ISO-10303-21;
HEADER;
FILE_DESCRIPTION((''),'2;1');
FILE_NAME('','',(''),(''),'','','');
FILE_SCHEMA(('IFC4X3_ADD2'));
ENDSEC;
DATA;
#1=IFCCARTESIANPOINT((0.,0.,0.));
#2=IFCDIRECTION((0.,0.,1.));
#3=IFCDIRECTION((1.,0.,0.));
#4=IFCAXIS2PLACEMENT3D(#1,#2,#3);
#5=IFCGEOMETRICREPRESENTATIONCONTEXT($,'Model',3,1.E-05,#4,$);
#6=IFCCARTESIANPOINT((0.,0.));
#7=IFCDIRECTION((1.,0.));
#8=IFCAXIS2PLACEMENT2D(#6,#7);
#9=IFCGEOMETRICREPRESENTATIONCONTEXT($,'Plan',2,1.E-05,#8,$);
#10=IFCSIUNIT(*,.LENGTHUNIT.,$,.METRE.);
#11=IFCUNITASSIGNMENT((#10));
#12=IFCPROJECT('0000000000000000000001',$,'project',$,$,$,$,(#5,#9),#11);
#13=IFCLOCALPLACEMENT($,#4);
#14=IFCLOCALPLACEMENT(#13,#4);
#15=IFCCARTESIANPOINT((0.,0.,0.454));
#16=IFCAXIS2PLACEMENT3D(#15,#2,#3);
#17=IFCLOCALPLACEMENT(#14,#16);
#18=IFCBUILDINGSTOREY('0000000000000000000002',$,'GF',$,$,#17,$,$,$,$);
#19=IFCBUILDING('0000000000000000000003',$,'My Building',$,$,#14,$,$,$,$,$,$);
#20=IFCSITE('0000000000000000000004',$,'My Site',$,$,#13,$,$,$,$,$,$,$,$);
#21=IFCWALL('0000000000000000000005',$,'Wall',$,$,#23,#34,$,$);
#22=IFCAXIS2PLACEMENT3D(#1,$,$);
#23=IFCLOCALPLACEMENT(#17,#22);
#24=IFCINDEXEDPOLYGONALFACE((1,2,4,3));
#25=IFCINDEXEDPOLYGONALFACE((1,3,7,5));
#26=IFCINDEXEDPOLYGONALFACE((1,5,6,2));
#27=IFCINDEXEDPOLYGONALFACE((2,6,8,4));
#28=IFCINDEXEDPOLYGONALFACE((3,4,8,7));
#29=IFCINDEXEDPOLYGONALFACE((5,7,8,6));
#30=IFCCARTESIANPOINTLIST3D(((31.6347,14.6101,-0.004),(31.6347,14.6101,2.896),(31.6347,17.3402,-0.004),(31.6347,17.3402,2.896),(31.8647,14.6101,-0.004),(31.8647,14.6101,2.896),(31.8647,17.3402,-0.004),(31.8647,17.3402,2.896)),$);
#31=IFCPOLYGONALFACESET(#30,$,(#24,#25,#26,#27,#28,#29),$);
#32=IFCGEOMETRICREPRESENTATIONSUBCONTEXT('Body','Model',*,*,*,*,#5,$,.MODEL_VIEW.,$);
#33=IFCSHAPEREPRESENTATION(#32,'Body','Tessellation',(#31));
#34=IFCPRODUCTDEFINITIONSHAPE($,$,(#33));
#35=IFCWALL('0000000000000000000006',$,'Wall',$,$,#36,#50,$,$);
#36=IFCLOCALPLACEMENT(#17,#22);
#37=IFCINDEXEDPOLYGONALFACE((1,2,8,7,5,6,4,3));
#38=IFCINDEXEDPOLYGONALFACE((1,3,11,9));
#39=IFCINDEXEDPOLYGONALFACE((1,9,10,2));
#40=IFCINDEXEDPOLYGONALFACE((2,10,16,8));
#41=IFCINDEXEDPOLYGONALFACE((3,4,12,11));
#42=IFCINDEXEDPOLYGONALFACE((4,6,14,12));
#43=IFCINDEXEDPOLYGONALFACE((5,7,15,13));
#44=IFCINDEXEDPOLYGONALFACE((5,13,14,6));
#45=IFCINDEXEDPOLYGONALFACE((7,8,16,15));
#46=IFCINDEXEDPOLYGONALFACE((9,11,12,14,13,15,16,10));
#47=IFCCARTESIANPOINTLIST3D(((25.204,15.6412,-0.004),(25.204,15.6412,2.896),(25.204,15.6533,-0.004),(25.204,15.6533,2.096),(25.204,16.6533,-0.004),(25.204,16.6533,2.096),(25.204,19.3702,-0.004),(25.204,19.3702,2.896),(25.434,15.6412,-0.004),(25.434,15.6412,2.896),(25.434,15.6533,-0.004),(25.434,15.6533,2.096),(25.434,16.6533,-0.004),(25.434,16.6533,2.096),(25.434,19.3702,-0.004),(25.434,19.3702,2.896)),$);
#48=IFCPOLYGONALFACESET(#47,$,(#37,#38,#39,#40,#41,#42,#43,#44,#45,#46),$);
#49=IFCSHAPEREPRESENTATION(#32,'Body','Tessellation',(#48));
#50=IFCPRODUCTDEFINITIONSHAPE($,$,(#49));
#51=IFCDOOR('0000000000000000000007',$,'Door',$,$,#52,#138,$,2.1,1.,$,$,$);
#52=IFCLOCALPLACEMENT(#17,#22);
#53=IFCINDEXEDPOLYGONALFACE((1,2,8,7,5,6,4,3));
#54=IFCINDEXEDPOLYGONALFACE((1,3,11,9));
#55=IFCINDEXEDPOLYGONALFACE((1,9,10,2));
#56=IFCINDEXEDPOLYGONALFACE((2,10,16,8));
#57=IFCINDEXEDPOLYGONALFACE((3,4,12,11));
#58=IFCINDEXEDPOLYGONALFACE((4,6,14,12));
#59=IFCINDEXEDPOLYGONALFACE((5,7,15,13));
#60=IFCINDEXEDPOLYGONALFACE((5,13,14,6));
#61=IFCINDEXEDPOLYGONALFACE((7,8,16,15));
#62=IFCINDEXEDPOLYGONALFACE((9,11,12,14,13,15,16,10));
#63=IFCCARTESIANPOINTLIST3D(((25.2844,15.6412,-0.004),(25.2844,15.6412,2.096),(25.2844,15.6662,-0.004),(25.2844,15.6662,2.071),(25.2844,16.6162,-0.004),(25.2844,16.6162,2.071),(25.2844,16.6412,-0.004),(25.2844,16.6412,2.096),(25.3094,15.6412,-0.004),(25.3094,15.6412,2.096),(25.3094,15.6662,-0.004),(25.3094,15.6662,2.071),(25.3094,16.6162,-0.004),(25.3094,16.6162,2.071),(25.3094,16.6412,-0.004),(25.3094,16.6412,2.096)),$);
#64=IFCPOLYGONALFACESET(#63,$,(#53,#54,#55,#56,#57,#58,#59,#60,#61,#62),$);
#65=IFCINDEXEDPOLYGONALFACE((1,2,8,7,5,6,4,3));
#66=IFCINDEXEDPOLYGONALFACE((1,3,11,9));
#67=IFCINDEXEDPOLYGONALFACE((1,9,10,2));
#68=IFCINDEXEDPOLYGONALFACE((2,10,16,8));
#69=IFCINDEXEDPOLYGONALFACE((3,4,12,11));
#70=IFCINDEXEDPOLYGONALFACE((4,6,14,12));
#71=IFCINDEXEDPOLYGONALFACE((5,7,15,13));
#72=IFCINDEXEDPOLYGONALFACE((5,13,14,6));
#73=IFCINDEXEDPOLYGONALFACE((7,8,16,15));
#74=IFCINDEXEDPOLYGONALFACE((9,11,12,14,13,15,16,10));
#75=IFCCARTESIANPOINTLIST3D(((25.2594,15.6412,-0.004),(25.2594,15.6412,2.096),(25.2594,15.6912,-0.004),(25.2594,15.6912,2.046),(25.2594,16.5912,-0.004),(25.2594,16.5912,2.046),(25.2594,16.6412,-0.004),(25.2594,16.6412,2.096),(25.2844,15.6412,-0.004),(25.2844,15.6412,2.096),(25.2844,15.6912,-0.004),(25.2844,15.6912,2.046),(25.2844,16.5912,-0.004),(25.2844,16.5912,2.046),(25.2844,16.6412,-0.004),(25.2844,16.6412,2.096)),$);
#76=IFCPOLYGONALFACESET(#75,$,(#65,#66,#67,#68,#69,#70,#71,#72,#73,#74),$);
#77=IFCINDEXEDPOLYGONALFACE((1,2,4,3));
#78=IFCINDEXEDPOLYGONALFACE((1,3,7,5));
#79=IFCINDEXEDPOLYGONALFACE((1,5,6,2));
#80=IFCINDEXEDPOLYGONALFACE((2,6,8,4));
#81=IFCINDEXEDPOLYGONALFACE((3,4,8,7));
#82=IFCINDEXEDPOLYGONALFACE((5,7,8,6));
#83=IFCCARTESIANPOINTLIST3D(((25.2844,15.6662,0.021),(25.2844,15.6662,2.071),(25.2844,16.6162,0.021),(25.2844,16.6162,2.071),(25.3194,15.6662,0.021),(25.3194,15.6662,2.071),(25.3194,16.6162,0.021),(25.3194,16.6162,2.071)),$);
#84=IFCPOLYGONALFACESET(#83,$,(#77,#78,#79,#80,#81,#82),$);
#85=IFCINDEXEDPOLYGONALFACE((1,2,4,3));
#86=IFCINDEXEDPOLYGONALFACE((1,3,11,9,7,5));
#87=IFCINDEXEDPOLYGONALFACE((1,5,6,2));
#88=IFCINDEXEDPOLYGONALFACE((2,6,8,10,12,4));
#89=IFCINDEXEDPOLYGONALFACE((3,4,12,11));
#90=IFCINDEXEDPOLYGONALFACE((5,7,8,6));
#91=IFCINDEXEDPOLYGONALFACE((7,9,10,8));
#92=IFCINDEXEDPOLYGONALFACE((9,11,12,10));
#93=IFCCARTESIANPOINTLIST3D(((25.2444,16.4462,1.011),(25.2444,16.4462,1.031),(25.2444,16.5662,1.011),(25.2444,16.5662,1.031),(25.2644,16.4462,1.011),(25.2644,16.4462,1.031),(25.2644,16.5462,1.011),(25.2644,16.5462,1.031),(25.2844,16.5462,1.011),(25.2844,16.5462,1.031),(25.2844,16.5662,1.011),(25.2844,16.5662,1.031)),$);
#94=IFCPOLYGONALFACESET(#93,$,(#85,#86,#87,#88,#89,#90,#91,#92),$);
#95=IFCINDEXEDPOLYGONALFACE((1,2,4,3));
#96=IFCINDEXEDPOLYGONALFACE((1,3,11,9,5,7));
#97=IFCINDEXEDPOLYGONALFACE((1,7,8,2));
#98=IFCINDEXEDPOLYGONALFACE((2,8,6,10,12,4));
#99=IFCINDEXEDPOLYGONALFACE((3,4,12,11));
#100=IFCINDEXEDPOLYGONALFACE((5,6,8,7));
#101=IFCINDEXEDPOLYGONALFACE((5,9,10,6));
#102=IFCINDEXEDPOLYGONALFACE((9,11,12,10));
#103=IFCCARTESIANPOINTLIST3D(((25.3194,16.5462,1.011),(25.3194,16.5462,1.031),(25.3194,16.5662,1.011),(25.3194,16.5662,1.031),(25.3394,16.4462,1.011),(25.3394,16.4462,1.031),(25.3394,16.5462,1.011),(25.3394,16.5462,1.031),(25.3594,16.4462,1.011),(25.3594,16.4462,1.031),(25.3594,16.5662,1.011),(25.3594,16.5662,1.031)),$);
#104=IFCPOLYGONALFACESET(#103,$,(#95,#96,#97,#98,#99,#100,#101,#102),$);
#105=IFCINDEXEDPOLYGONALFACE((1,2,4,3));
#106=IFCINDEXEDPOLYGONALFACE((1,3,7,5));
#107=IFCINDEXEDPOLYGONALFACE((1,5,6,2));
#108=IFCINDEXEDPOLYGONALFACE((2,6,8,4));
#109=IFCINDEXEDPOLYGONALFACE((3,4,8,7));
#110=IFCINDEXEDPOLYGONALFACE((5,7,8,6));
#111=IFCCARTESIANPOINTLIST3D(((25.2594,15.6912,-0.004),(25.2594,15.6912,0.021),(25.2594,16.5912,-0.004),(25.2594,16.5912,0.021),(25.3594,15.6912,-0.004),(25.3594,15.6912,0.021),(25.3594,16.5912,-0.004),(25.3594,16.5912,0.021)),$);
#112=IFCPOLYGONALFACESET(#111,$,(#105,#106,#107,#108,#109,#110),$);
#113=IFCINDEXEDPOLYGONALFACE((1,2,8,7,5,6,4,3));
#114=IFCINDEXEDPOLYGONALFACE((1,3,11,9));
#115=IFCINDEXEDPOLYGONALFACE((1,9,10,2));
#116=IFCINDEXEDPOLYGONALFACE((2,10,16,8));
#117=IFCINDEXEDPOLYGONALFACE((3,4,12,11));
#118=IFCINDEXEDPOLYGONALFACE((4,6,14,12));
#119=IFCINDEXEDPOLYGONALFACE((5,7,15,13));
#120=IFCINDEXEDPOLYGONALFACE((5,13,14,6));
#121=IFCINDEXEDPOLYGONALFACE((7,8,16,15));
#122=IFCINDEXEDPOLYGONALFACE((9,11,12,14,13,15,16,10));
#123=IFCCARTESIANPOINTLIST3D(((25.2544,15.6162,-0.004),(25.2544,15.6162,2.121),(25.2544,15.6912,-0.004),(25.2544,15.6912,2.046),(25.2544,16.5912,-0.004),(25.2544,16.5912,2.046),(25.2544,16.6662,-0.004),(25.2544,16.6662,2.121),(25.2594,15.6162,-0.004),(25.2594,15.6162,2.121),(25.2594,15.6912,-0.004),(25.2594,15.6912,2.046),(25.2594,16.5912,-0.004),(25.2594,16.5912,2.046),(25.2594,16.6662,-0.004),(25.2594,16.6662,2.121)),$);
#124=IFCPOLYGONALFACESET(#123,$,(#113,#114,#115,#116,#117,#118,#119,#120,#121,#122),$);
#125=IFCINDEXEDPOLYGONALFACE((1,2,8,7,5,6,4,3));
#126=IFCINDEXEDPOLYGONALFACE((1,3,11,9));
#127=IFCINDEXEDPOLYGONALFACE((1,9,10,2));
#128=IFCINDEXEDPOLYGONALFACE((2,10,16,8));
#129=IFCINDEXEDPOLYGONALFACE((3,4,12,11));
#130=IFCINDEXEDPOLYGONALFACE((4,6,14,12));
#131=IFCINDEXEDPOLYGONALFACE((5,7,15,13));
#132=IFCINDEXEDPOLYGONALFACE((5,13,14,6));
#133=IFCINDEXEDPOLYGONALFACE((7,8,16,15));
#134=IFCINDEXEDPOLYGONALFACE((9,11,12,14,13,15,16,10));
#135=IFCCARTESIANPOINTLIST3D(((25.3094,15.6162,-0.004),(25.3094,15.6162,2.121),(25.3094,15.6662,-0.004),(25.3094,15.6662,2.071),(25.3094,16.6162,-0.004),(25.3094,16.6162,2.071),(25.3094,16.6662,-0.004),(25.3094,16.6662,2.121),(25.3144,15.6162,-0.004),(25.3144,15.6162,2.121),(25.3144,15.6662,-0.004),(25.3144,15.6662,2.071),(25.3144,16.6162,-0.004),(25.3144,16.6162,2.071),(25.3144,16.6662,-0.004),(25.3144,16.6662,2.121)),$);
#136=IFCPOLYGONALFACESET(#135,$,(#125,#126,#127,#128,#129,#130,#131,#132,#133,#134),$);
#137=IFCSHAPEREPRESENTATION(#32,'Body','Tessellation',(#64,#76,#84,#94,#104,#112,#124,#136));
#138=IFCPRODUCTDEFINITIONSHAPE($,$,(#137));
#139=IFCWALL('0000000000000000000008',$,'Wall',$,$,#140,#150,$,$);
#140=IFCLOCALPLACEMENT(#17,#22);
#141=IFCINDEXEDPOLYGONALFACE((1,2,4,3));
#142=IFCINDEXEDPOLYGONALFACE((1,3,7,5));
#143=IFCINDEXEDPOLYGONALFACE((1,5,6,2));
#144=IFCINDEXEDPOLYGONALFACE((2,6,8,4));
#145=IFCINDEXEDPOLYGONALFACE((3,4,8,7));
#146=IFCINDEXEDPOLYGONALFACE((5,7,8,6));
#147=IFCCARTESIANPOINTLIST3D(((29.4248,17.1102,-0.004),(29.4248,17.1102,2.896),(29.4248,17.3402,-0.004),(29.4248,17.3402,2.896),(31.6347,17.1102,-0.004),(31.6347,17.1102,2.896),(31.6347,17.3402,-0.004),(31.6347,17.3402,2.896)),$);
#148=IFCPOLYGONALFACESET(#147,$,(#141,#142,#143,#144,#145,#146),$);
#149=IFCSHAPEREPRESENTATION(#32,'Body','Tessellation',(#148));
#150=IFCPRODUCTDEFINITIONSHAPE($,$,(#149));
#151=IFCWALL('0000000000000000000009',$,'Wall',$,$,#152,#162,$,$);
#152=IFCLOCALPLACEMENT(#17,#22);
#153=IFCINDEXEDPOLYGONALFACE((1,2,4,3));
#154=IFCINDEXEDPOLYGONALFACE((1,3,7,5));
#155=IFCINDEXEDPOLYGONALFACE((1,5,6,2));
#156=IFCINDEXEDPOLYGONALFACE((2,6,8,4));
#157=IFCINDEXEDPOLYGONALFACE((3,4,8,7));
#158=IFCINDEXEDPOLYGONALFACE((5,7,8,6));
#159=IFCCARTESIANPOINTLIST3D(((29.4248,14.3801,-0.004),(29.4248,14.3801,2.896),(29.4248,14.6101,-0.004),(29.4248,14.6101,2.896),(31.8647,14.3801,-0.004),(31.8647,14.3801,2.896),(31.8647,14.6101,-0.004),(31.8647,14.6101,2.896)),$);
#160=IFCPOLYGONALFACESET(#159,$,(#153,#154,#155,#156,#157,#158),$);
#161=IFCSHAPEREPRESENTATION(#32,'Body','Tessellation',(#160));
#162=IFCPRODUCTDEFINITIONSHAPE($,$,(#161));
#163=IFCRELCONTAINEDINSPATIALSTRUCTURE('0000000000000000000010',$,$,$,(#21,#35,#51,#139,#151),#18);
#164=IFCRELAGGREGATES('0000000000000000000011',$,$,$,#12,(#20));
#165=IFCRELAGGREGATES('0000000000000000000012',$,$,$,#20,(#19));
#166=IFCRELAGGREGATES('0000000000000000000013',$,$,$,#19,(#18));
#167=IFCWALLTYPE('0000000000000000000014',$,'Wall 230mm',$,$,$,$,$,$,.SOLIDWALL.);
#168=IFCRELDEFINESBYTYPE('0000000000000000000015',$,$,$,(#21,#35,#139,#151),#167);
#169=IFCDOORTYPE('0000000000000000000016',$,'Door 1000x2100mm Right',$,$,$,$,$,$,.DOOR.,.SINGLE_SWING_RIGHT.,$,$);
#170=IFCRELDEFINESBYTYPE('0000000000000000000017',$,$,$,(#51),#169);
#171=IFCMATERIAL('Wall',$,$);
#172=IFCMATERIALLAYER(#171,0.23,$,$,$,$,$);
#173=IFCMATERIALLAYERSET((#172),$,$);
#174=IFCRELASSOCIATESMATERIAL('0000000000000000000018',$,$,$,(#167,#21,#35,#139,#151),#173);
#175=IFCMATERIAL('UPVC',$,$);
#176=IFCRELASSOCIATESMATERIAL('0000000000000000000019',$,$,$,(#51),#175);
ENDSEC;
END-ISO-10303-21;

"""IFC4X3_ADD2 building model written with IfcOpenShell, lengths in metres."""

from ifc_helpers import new_model, entity, si_unit, frame, origin_with_axes, origin_2d_with_axis, place, context, subcontext, project, spatial, line, indexed_curve, outline, extrude, shape, source, transform, mapped, material, layer, layer_set, layer_usage, type_object, type_shapes, element, fill, save


model = new_model("IFC4X3_ADD2")

# Units and contexts
model_context = context("Model", 3, precision=1e-05, world=origin_with_axes())
plan_context = context("Plan", 2, precision=1e-05, world=origin_2d_with_axis())
body_context_1 = subcontext(model_context, "Body", "Model", "MODEL_VIEW")
body_context_2 = subcontext(plan_context, "Body", "Plan", "PLAN_VIEW")
ifc_project = project(units=[si_unit("LENGTHUNIT", "METRE")], contexts=[model_context, plan_context])

# Site, building, storey
site_placement = place(None, origin_with_axes())
site = spatial("IfcSite", under=ifc_project, at=site_placement, Name="My Site")
building_placement = place(site_placement, origin_with_axes())
building = spatial("IfcBuilding", under=site, at=building_placement, Name="My Building")
storey_placement = place(building_placement, frame((0.0, 0.0, 0.454), z_axis=(0.0, 0.0, 1.0), x_axis=(1.0, 0.0, 0.0)))
storey = spatial("IfcBuildingStorey", under=building, at=storey_placement, Name="GF")

# Shared definitions
ifc_material_1 = material(Name="Wall")

# Shared definitions
ifc_material_2 = material(Name="UPVC")

# Wall
ifc_layer_1 = layer(ifc_material_1, 0.23)
ifc_layer_set_1 = layer_set([ifc_layer_1])
ifc_layer_usage_1 = layer_usage(ifc_layer_set_1, "AXIS2", "POSITIVE", 0.0)
wall_type_1 = type_object("IfcWallType", Name="Wall 230mm", PredefinedType="SOLIDWALL", material=ifc_layer_set_1)
wall_1_placement = place(storey_placement, frame((31.8647, 14.6101, -0.004), z_axis=(0.0, 0.0, 1.0), x_axis=(0.000001, 1.0, 0.0)))
element("IfcWall", 1, at=wall_1_placement, inside=storey, type_object=wall_type_1, material=ifc_layer_usage_1, Name="Wall", context=body_context_1, shape_type="SweptSolid", body=[
    extrude(outline(indexed_curve([(0.0, 0.0), (0.0, 0.23), (2.73, 0.23), (2.73, 0.0), (0.0, 0.0)], self_intersect=False)), origin_with_axes(), (0.0, 0.0, 1.0), 2.9),
])

# Wall, opening, door
ifc_layer_usage_2 = layer_usage(ifc_layer_set_1, "AXIS2", "POSITIVE", 0.0)
wall_2_placement = place(storey_placement, frame((25.434, 15.6412, -0.004), z_axis=(0.0, 0.0, 1.0), x_axis=(0.000001, 1.0, 0.0)))
wall_2 = element("IfcWall", 2, at=wall_2_placement, inside=storey, type_object=wall_type_1, material=ifc_layer_usage_2, Name="Wall", context=body_context_1, shape_type="SweptSolid", body=[
    extrude(outline(indexed_curve([(0.0, 0.0), (0.0, 0.23), (3.729, 0.23), (3.729, 0.0), (0.0, 0.0)], self_intersect=False)), origin_with_axes(), (0.0, 0.0, 1.0), 2.9),
])
shared_shape_1 = source(origin_with_axes(), body_context_1, "Body", "SweptSolid", [
    extrude(outline(indexed_curve([(0.0, 0.0), (1.0, 0.0), (1.0, 2.1), (0.0, 2.1)], segments=[line(1, 2, 3, 4, 1)])), frame((0.0, -0.6, 0.0), z_axis=(0.0, -1.0, 0.0), x_axis=(1.0, 0.0, 0.0)), (0.0, 0.0, -1.0), 1.2),
])
opening_1_placement = place(wall_2_placement, frame((0.012, 0.0, 0.0), z_axis=(0.0, 0.0, 1.0), x_axis=(1.0, 0.0, 0.0)))
opening_1 = element("IfcOpeningElement", 3, at=opening_1_placement, cuts=wall_2, PredefinedType="OPENING", context=body_context_1, shape_type="MappedRepresentation", body=[
    mapped(shared_shape_1, transform((0.0, 0.0, 0.0), x_axis=(1.0, 0.0, 0.0), y_axis=(0.0, 1.0, 0.0), z_axis=(0.0, 0.0, 1.0), scale=1.0)),
])
door_type_1 = type_object("IfcDoorType", Name="Door 1000x2100mm Right", OperationType="SINGLE_SWING_RIGHT", PredefinedType="DOOR")
shared_shape_2 = source(origin_with_axes(), body_context_1, "Body", "SweptSolid", [
    extrude(outline(indexed_curve([(0.0, 0.0), (0.0, 2.1), (1.0, 2.1), (1.0, 0.0), (0.975, 0.0), (0.975, 2.075), (0.025, 2.075), (0.025, 0.0)], segments=[line(1, 2, 3, 4, 5, 6, 7, 8, 1)])), frame((0.0, 0.025, 0.0), z_axis=(0.0, -1.0, 0.0), x_axis=(1.0, 0.0, 0.0)), (0.0, 0.0, -1.0), 0.025),
    extrude(outline(indexed_curve([(0.0, 0.0), (0.0, 2.1), (1.0, 2.1), (1.0, 0.0), (0.95, 0.0), (0.95, 2.05), (0.05, 2.05), (0.05, 0.0)], segments=[line(1, 2, 3, 4, 5, 6, 7, 8, 1)])), frame((0.0, 0.0, 0.0), z_axis=(0.0, -1.0, 0.0), x_axis=(1.0, 0.0, 0.0)), (0.0, 0.0, -1.0), 0.025),
    extrude(outline(indexed_curve([(0.0, 0.0), (0.95, 0.0), (0.95, 0.035), (0.0, 0.035)], segments=[line(1, 2, 3, 4, 1)])), frame((0.025, 0.025, 0.025), z_axis=(0.0, 0.0, 1.0), x_axis=(1.0, 0.0, 0.0)), (0.0, 0.0, 1.0), 2.05),
    extrude(outline(indexed_curve([(0.0, 0.0), (0.0, -0.04), (0.12, -0.04), (0.12, -0.02), (0.02, -0.02), (0.02, 0.0)], segments=[line(1, 2, 3, 4, 5, 6, 1)])), frame((0.075, 0.025, 1.015), z_axis=(0.0, 0.0, 1.0), x_axis=(1.0, 0.0, 0.0)), (0.0, 0.0, 1.0), 0.02),
    extrude(outline(indexed_curve([(0.0, 0.0), (0.0, 0.04), (0.12, 0.04), (0.12, 0.02), (0.02, 0.02), (0.02, 0.0)], segments=[line(1, 2, 3, 4, 5, 6, 1)])), frame((0.075, 0.06, 1.015), z_axis=(0.0, 0.0, 1.0), x_axis=(1.0, 0.0, 0.0)), (0.0, 0.0, 1.0), 0.02),
    extrude(outline(indexed_curve([(0.0, 0.0), (0.9, 0.0), (0.9, 0.1), (0.0, 0.1)], segments=[line(1, 2, 3, 4, 1)])), frame((0.05, 0.0, 0.0), z_axis=(0.0, 0.0, 1.0), x_axis=(1.0, 0.0, 0.0)), (0.0, 0.0, 1.0), 0.025),
    extrude(outline(indexed_curve([(0.0, 0.0), (0.0, 2.125), (1.05, 2.125), (1.05, 0.0), (0.975, 0.0), (0.975, 2.05), (0.075, 2.05), (0.075, 0.0)], segments=[line(1, 2, 3, 4, 5, 6, 7, 8, 1)])), frame((-0.025, -0.005, 0.0), z_axis=(0.0, -1.0, 0.0), x_axis=(1.0, 0.0, 0.0)), (0.0, 0.0, -1.0), 0.005),
    extrude(outline(indexed_curve([(0.0, 0.0), (0.0, 2.125), (1.05, 2.125), (1.05, 0.0), (1.0, 0.0), (1.0, 2.075), (0.05, 2.075), (0.05, 0.0)], segments=[line(1, 2, 3, 4, 5, 6, 7, 8, 1)])), frame((-0.025, 0.05, 0.0), z_axis=(0.0, -1.0, 0.0), x_axis=(1.0, 0.0, 0.0)), (0.0, 0.0, -1.0), 0.005),
])
shared_shape_3 = source(origin_with_axes(), body_context_2, "Body", "Curve2D", [
    entity("IfcIndexedPolyCurve", entity("IfcCartesianPointList2D", [[0.0, 0.0], [0.0, 0.05], [0.025, 0.05], [0.025, 0.025], [0.05, 0.025], [0.05, 0.0]]), [entity("IfcLineIndex", [1, 2, 3, 4, 5, 6, 1])]),
    entity("IfcIndexedPolyCurve", entity("IfcCartesianPointList2D", [[1.0, 0.0], [1.0, 0.05], [0.975, 0.05], [0.975, 0.025], [0.95, 0.025], [0.95, 0.0]]), [entity("IfcLineIndex", [1, 2, 3, 4, 5, 6, 1])]),
    entity("IfcTrimmedCurve", entity("IfcEllipse", entity("IfcAxis2Placement2D", entity("IfcCartesianPoint", [0.94, 0.05]), entity("IfcDirection", [1.0, 0.0])), 0.915, 0.95), [entity("IfcCartesianPoint", [0.94, 1.0])], [entity("IfcCartesianPoint", [0.025, 0.05])], True, "CARTESIAN"),
    entity("IfcIndexedPolyCurve", entity("IfcCartesianPointList2D", [[0.975, 0.05], [0.94, 0.05], [0.94, 1.0], [0.975, 1.0]]), [entity("IfcLineIndex", [1, 2, 3, 4, 1])]),
])
type_shapes(door_type_1, [shared_shape_2, shared_shape_3])
door_1_placement = place(opening_1_placement, frame((0.988, 0.1746, 0.0), z_axis=(0.0, 0.0, 1.0), x_axis=(-1.0, 0.0, 0.0)))
door_1 = element("IfcDoor", 4, at=door_1_placement, inside=storey, type_object=door_type_1, material=ifc_material_2, Name="Door", OverallHeight=2.1, OverallWidth=1.0, shapes=[
    shape(body_context_1, "Body", "MappedRepresentation", [mapped(shared_shape_2, transform((0.0, 0.0, 0.0), x_axis=(1.0, 0.0, 0.0), y_axis=(0.0, 1.0, 0.0), z_axis=(0.0, 0.0, 1.0), scale=1.0))]),
    shape(body_context_2, "Body", "MappedRepresentation", [mapped(shared_shape_3, transform((0.0, 0.0, 0.0), x_axis=(1.0, 0.0, 0.0), y_axis=(0.0, 1.0, 0.0), z_axis=(0.0, 0.0, 1.0), scale=1.0))]),
])
fill(opening_1, door_1)

# Walls
ifc_layer_usage_3 = layer_usage(ifc_layer_set_1, "AXIS2", "POSITIVE", 0.0)
wall_3_placement = place(storey_placement, frame((31.6347, 17.3402, -0.004), z_axis=(0.0, 0.0, 1.0), x_axis=(-1.0, 0.0, 0.0)))
element("IfcWall", 5, at=wall_3_placement, inside=storey, type_object=wall_type_1, material=ifc_layer_usage_3, Name="Wall", context=body_context_1, shape_type="SweptSolid", body=[
    extrude(outline(indexed_curve([(0.0, 0.0), (0.0, 0.23), (2.21, 0.23), (2.21, 0.0), (0.0, 0.0)], self_intersect=False)), origin_with_axes(), (0.0, 0.0, 1.0), 2.9),
])
ifc_layer_usage_4 = layer_usage(ifc_layer_set_1, "AXIS2", "POSITIVE", 0.0)
wall_4_placement = place(storey_placement, frame((31.8647, 14.6101, -0.004), z_axis=(0.0, 0.0, 1.0), x_axis=(-1.0, 0.0, 0.0)))
element("IfcWall", 6, at=wall_4_placement, inside=storey, type_object=wall_type_1, material=ifc_layer_usage_4, Name="Wall", context=body_context_1, shape_type="SweptSolid", body=[
    extrude(outline(indexed_curve([(0.0, 0.0), (0.0, 0.23), (2.44, 0.23), (2.44, 0.0), (0.0, 0.0)], self_intersect=False)), origin_with_axes(), (0.0, 0.0, 1.0), 2.9),
])

save(model, "model.ifc")
